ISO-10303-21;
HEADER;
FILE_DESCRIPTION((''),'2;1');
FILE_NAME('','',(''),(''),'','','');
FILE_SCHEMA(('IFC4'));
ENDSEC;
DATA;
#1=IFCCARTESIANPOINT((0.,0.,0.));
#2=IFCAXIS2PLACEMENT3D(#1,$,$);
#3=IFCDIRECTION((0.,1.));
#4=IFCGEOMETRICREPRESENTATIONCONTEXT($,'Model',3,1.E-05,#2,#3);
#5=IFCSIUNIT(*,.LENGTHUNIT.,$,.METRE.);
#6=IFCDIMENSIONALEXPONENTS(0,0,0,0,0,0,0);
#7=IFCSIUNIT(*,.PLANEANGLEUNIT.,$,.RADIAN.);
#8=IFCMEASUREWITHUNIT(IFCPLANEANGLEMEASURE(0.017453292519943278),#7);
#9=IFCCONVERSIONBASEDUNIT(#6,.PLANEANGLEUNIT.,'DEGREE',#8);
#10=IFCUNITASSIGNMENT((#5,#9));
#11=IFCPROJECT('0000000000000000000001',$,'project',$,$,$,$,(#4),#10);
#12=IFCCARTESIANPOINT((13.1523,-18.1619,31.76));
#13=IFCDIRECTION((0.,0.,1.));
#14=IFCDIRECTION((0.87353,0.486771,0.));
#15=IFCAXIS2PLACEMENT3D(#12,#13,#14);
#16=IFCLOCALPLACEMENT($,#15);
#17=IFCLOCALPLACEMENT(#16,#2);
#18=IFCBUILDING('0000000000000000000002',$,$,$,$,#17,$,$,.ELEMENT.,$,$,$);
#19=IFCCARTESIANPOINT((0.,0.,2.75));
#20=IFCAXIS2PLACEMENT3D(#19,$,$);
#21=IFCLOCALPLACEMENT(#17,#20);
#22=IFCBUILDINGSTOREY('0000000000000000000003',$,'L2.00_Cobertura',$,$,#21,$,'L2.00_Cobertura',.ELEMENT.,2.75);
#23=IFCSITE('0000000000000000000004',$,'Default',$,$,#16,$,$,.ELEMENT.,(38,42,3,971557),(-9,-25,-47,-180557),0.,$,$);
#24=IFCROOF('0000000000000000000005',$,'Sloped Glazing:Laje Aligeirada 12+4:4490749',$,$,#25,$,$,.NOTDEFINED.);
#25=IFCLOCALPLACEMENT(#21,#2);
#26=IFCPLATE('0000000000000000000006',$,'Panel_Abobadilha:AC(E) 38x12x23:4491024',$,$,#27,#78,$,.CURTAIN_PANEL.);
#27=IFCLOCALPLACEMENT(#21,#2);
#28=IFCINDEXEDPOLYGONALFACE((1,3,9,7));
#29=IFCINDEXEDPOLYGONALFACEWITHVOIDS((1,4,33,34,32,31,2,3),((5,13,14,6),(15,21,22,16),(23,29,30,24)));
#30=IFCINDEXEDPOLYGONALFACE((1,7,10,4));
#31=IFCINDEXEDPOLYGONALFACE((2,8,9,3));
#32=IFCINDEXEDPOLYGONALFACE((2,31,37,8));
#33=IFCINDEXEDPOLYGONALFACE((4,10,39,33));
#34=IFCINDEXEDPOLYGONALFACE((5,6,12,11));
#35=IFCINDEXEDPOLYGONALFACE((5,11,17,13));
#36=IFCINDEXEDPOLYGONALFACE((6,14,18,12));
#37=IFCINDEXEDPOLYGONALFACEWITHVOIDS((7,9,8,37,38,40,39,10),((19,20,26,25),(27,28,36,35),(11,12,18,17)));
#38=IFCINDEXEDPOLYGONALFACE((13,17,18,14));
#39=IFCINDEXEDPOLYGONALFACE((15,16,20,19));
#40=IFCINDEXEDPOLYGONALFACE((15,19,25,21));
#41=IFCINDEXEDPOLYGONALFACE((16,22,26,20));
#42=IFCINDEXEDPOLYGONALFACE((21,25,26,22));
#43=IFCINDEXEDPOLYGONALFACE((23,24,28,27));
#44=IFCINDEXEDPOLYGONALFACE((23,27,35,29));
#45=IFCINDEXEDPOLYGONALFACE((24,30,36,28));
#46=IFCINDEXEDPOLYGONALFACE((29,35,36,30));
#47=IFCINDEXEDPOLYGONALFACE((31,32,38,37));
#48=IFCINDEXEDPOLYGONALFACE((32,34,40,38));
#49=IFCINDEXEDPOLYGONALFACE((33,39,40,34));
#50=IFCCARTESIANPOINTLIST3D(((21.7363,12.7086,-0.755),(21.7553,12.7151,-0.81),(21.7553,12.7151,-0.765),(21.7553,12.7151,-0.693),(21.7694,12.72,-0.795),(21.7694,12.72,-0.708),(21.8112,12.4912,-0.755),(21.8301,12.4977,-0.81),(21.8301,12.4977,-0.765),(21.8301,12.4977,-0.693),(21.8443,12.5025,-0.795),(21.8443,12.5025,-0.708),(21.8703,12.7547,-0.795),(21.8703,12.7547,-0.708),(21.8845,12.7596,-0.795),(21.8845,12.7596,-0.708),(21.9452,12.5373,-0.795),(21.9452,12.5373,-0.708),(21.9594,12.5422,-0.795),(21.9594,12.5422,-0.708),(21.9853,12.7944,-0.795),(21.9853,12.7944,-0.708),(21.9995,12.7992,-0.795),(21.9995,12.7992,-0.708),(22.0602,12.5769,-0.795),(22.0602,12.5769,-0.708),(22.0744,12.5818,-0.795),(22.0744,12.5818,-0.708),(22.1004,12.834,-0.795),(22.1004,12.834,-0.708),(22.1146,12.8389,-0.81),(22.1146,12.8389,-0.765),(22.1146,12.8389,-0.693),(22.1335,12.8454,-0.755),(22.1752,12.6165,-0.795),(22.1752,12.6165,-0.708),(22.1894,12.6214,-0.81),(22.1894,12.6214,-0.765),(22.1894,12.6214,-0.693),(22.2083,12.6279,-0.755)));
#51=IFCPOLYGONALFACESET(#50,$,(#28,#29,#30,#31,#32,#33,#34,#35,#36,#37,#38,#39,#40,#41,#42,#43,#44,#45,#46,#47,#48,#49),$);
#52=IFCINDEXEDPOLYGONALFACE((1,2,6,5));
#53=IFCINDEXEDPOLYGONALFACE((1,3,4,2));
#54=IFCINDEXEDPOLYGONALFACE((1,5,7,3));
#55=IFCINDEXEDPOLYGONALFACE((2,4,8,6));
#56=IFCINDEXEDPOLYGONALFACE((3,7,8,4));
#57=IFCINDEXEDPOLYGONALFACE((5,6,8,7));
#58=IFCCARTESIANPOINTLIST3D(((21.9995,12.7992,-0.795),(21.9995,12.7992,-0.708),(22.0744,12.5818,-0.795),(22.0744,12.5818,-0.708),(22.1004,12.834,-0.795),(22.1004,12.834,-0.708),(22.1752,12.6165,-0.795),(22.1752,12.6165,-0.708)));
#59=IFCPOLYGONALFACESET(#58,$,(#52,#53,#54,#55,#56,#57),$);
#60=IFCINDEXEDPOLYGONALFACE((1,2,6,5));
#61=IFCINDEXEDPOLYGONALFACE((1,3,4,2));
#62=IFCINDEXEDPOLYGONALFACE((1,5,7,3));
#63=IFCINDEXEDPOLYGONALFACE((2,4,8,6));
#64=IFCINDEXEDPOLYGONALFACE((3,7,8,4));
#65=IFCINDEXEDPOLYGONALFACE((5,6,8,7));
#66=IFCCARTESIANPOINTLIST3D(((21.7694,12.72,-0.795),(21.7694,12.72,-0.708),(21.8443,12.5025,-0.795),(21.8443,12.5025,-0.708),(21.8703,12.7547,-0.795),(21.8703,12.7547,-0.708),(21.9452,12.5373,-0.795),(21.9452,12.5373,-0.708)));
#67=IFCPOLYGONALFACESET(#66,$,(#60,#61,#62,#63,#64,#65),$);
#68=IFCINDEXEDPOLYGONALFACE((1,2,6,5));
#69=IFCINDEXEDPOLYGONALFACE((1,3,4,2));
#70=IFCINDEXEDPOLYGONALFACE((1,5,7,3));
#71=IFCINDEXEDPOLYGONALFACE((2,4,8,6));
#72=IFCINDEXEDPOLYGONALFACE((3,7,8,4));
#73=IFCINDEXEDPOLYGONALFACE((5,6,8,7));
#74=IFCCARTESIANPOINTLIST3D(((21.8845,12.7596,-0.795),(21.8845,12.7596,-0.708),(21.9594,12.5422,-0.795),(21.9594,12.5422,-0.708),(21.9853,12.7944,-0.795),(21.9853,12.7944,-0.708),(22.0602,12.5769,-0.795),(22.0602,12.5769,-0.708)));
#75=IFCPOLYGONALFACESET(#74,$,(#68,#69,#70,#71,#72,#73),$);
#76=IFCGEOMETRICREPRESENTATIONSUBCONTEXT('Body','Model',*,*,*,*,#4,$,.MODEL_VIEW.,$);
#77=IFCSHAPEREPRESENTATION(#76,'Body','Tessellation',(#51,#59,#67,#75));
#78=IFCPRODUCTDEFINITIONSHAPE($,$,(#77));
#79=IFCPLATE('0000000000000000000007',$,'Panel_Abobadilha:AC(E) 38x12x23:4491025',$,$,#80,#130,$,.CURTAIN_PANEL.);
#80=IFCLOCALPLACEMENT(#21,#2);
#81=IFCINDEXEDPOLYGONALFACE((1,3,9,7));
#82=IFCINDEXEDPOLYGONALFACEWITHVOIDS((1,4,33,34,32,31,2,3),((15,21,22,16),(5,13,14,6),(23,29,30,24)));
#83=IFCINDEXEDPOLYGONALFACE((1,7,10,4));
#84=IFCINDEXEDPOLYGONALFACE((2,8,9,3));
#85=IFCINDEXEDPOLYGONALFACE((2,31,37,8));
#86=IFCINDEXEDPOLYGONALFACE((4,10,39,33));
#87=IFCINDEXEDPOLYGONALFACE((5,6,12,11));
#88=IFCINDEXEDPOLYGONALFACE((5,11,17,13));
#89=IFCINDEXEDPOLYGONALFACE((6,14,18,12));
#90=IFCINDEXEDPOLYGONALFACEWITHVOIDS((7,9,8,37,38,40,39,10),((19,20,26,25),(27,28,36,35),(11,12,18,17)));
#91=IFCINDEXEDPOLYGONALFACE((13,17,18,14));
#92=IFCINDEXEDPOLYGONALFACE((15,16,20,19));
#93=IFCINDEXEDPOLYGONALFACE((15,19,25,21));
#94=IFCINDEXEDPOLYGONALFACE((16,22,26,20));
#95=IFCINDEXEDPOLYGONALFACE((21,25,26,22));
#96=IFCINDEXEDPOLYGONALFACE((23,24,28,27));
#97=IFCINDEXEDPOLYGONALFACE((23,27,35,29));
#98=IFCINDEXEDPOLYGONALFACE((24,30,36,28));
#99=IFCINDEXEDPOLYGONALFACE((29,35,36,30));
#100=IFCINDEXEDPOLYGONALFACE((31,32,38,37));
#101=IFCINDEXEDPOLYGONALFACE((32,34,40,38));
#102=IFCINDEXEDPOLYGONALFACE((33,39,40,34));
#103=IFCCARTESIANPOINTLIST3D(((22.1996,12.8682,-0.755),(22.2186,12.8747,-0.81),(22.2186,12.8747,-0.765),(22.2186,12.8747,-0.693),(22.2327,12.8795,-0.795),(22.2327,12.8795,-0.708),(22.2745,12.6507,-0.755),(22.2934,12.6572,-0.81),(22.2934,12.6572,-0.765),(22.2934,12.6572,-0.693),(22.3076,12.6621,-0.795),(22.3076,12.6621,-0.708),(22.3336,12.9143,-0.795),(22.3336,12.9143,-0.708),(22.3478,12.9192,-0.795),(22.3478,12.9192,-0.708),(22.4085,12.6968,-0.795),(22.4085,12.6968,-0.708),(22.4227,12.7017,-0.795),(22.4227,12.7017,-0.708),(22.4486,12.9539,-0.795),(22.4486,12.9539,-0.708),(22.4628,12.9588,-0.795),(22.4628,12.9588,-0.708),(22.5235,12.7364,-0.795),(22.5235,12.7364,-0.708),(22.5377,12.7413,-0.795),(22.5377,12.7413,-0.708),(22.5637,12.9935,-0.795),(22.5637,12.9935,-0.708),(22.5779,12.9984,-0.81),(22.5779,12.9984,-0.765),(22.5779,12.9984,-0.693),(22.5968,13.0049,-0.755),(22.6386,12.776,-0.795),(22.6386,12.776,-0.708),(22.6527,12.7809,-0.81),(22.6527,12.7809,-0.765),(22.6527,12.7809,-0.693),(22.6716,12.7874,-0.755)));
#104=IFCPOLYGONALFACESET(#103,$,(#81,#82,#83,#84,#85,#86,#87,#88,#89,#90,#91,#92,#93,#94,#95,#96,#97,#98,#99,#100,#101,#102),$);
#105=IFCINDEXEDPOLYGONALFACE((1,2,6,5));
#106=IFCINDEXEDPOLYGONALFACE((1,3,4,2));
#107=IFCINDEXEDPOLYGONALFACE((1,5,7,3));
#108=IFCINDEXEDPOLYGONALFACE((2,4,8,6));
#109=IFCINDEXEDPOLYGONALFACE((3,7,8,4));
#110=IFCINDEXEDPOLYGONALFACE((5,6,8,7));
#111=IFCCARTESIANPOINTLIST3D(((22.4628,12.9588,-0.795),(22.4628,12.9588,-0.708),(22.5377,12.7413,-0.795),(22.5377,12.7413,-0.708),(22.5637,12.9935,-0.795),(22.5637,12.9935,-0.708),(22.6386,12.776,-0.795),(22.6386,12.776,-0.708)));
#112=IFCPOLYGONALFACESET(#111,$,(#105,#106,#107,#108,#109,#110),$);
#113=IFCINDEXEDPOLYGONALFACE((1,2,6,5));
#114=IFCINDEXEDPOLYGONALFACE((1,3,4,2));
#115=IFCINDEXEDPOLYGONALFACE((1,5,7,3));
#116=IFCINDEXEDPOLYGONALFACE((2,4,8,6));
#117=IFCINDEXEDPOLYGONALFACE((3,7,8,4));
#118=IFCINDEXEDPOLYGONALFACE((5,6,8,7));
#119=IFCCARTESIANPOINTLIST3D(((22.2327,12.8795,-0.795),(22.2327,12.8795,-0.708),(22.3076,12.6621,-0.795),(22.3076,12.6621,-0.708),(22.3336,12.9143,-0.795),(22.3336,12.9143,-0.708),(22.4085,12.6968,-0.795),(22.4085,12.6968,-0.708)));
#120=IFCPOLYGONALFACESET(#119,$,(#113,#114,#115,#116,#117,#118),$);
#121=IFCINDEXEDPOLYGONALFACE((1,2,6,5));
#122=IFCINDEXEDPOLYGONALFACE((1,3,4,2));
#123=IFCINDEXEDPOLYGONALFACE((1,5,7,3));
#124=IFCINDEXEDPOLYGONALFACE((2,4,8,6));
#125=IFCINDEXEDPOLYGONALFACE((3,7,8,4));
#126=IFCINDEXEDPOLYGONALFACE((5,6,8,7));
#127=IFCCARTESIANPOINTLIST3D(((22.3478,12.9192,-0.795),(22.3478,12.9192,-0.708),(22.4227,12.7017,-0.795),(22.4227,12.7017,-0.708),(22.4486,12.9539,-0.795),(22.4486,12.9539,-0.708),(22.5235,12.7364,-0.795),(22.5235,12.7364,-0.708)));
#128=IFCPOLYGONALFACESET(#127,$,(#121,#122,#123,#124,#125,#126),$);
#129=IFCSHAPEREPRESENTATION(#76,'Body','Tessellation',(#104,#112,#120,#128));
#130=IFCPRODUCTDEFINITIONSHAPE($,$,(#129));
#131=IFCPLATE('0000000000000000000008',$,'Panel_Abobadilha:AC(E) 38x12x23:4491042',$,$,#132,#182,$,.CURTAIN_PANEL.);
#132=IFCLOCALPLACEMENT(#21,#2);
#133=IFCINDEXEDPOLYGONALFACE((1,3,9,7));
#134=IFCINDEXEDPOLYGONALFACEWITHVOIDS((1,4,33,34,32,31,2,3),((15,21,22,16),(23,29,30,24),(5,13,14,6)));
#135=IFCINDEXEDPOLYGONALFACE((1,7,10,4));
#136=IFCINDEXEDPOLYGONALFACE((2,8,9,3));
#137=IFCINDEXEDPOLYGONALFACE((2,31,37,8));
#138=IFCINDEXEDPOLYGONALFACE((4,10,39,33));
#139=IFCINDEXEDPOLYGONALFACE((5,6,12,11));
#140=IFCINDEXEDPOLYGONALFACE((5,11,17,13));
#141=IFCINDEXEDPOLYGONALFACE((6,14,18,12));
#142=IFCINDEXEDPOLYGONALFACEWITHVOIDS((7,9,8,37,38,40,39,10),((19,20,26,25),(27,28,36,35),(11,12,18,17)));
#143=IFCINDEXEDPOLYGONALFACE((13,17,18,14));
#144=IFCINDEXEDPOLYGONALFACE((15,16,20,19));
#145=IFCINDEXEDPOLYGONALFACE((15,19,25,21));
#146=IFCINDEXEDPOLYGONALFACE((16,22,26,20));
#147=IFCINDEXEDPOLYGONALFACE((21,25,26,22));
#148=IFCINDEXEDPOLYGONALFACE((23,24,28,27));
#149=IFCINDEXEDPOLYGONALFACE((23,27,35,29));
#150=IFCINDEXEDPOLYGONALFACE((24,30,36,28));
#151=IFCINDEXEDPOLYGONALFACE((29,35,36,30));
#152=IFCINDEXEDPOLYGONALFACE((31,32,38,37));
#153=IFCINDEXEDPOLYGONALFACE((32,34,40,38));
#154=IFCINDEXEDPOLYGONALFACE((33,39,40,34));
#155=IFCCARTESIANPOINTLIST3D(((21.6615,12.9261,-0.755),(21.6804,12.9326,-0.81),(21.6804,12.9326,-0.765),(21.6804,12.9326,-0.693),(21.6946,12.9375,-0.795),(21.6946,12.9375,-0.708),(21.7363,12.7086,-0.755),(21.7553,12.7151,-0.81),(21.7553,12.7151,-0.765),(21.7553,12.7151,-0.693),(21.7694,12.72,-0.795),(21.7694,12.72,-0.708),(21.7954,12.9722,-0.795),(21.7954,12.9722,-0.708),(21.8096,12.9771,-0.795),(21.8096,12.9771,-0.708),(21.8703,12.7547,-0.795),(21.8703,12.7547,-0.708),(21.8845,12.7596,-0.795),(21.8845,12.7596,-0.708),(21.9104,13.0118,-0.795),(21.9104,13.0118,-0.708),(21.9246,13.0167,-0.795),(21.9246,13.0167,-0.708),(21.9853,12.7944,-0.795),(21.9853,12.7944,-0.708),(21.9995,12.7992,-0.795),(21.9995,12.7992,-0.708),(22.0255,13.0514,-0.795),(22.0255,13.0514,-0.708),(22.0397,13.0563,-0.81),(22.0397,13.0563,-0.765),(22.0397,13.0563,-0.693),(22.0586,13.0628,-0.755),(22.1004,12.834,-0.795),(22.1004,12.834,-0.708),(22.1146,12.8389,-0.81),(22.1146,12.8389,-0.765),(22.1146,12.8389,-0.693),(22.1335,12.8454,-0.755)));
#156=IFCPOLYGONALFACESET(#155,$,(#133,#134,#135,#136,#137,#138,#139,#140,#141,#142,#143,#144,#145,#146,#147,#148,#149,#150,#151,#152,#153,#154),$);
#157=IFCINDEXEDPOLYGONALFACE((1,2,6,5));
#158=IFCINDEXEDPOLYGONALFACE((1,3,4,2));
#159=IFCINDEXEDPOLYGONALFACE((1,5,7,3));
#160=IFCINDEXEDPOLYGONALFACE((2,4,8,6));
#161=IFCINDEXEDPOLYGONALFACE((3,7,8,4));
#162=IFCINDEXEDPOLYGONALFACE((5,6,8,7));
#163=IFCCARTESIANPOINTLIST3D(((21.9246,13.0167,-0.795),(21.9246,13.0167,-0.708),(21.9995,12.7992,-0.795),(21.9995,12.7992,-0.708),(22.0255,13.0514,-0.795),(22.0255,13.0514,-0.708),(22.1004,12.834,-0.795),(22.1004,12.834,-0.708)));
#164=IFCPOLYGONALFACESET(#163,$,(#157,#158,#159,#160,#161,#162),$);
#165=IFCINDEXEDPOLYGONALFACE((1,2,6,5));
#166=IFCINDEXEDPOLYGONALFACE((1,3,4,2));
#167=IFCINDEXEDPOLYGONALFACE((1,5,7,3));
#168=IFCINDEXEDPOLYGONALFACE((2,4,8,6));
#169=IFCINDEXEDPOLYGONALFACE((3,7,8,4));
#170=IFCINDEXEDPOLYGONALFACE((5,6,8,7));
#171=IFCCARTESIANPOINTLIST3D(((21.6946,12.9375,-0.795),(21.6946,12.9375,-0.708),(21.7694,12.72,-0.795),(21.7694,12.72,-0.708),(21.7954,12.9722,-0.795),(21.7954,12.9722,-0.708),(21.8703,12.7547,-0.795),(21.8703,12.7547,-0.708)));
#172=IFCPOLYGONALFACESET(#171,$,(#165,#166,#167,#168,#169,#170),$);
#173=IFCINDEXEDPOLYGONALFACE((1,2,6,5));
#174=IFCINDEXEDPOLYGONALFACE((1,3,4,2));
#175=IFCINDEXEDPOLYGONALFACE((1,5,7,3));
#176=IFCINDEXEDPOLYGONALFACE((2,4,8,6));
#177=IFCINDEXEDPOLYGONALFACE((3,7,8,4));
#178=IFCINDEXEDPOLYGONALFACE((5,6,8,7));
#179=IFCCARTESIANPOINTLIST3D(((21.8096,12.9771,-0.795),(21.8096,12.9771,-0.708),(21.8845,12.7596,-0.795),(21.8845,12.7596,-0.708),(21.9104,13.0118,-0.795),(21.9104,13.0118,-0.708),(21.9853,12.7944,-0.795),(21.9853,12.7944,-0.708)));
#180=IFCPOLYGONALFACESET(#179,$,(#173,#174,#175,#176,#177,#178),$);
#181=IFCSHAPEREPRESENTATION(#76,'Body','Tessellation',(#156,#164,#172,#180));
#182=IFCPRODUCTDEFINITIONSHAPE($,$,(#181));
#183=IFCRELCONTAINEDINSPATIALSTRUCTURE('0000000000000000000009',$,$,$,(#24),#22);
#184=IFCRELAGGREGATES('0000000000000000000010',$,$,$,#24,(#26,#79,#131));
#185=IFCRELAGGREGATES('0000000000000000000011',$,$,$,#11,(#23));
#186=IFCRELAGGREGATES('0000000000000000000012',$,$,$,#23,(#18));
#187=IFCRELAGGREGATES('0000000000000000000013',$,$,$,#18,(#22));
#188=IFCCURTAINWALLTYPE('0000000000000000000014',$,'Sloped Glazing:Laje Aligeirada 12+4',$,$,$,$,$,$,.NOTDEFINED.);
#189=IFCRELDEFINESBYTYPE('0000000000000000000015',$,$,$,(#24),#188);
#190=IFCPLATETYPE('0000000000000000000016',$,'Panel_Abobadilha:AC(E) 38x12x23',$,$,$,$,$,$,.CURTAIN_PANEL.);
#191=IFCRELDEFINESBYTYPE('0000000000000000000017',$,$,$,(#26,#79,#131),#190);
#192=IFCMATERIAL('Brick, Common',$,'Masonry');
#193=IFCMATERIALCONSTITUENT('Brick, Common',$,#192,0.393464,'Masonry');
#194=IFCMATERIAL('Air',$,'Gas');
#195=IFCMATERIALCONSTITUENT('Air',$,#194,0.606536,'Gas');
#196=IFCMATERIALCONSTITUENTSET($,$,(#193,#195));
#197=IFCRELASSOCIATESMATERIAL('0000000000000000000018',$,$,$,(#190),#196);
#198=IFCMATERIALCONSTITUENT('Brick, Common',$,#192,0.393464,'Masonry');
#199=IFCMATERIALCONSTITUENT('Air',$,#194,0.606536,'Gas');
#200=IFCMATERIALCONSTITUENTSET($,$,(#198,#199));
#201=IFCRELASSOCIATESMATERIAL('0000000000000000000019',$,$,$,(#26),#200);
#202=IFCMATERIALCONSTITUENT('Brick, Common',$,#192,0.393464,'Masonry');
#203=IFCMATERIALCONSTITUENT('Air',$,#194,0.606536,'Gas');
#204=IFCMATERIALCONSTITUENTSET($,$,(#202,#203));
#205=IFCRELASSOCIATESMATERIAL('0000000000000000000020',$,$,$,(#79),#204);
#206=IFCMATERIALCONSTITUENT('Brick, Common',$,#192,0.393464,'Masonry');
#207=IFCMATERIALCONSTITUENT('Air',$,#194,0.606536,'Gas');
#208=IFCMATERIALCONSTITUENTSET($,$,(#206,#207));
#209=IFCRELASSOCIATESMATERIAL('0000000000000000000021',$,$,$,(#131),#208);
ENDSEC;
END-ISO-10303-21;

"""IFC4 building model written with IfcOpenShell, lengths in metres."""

from ifc_helpers import new_model, entity, si_unit, converted_unit, direction, frame, origin, place, context, subcontext, project, spatial, indexed_curve, outline, extrude, source, transform, mapped, material, constituent, constituent_set, type_object, type_shapes, element, aggregate, save


model = new_model("IFC4")

# Units and contexts
model_context = context("Model", 3, precision=1e-05, world=origin(), true_north=direction((0.0, 1.0)))
body_context = subcontext(model_context, "Body", "Model", "MODEL_VIEW")
ifc_project = project(units=[si_unit("LENGTHUNIT", "METRE"), converted_unit("PLANEANGLEUNIT", "DEGREE", entity("IfcPlaneAngleMeasure", 0.017453292519943278), si_unit("PLANEANGLEUNIT", "RADIAN"), dimensions=[0, 0, 0, 0, 0, 0, 0])], contexts=[model_context])

# Site, building, storey
site_placement = place(None, frame((13.1523, -18.1619, 31.76), z_axis=(0.0, 0.0, 1.0), x_axis=(0.87353, 0.486771, 0.0)))
site = spatial("IfcSite", under=ifc_project, at=site_placement, Name="Default", CompositionType="ELEMENT", RefLatitude=(38, 42, 3, 971557), RefLongitude=(-9, -25, -47, -180557), RefElevation=0.0)
building_placement = place(site_placement, origin())
building = spatial("IfcBuilding", under=site, at=building_placement, CompositionType="ELEMENT")
storey_placement = place(building_placement, frame((0.0, 0.0, 2.75)))
storey = spatial("IfcBuildingStorey", under=building, at=storey_placement, Name="L2.00_Cobertura", LongName="L2.00_Cobertura", CompositionType="ELEMENT", Elevation=2.75)

# Roof, plates
curtain_wall_type = type_object("IfcCurtainWallType", Name="Sloped Glazing:Laje Aligeirada 12+4", PredefinedType="NOTDEFINED")
roof_placement = place(storey_placement, frame((0.0, 0.0, -2.75)))
roof = element("IfcRoof", 1, at=roof_placement, inside=storey, type_object=curtain_wall_type, Name="Sloped Glazing:Laje Aligeirada 12+4:4490749", PredefinedType="NOTDEFINED")
ifc_material_1 = material(Name="Brick, Common", Category="Masonry")
ifc_material_2 = material(Name="Air", Category="Gas")
ifc_constituent_1 = constituent(ifc_material_1, Name="Brick, Common", Category="Masonry", fraction=0.393464)
ifc_constituent_2 = constituent(ifc_material_2, Name="Air", Category="Gas", fraction=0.606536)
ifc_constituent_set_1 = constituent_set(constituents=[ifc_constituent_1, ifc_constituent_2])
plate_type = type_object("IfcPlateType", Name="Panel_Abobadilha:AC(E) 38x12x23", PredefinedType="CURTAIN_PANEL", material=ifc_constituent_set_1)
shared_shape_1 = source(origin(), body_context, "Body", "SweptSolid", [
    extrude(outline(indexed_curve([(-0.19, -0.0543), (0.19, -0.0543), (0.19, -0.0093), (0.21, 0.0007), (0.19, 0.0628), (-0.19, 0.0628), (-0.21, 0.0007), (-0.19, -0.0093), (-0.19, -0.0543)], self_intersect=False), holes=[indexed_curve([(-0.0683, 0.0477), (-0.0683, -0.0393), (-0.175, -0.0393), (-0.175, 0.0477), (-0.0683, 0.0477)], self_intersect=False), indexed_curve([(0.0533, 0.0477), (0.0533, -0.0393), (-0.0533, -0.0393), (-0.0533, 0.0477), (0.0533, 0.0477)], self_intersect=False), indexed_curve([(0.175, 0.0477), (0.175, -0.0393), (0.0683, -0.0393), (0.0683, 0.0477), (0.175, 0.0477)], self_intersect=False)]), frame((0.0, 0.0543, 0.0)), (0.0, 0.0, 1.0), 0.23),
    extrude(outline(indexed_curve([(-0.0533, -0.0435), (0.0533, -0.0435), (0.0533, 0.0435), (-0.0533, 0.0435), (-0.0533, -0.0435)], self_intersect=False)), frame((0.1217, 0.0585, 0.0), z_axis=(0.0, 0.0, 1.0), x_axis=(-1.0, 0.0, 0.0)), (0.0, 0.0, 1.0), 0.23),
    extrude(outline(indexed_curve([(-0.0533, -0.0435), (0.0533, -0.0435), (0.0533, 0.0435), (-0.0533, 0.0435), (-0.0533, -0.0435)], self_intersect=False)), frame((-0.1217, 0.0585, 0.0), z_axis=(0.0, 0.0, 1.0), x_axis=(-1.0, 0.0, 0.0)), (0.0, 0.0, 1.0), 0.23),
    extrude(outline(indexed_curve([(-0.0533, -0.0435), (0.0533, -0.0435), (0.0533, 0.0435), (-0.0533, 0.0435), (-0.0533, -0.0435)], self_intersect=False)), frame((0.0, 0.0585, 0.0), z_axis=(0.0, 0.0, 1.0), x_axis=(-1.0, 0.0, 0.0)), (0.0, 0.0, 1.0), 0.23),
])
type_shapes(plate_type, [shared_shape_1])
ifc_constituent_3 = constituent(ifc_material_1, Name="Brick, Common", Category="Masonry", fraction=0.393464)
ifc_constituent_4 = constituent(ifc_material_2, Name="Air", Category="Gas", fraction=0.606536)
ifc_constituent_set_2 = constituent_set(constituents=[ifc_constituent_3, ifc_constituent_4])
plate_1_placement = place(roof_placement, frame((21.9349, 12.777, 1.94), z_axis=(0.325568, -0.945519, 0.0), x_axis=(0.945519, 0.325568, 0.0)))
plate_1 = element("IfcPlate", 2, at=plate_1_placement, type_object=plate_type, material=ifc_constituent_set_2, Name="Panel_Abobadilha:AC(E) 38x12x23:4491024", PredefinedType="CURTAIN_PANEL", context=body_context, shape_type="MappedRepresentation", body=[
    mapped(shared_shape_1, transform((0.0, 0.0, 0.0), scale=1.0)),
])
ifc_constituent_5 = constituent(ifc_material_1, Name="Brick, Common", Category="Masonry", fraction=0.393464)
ifc_constituent_6 = constituent(ifc_material_2, Name="Air", Category="Gas", fraction=0.606536)
ifc_constituent_set_3 = constituent_set(constituents=[ifc_constituent_5, ifc_constituent_6])
plate_2_placement = place(roof_placement, frame((22.3982, 12.9365, 1.94), z_axis=(0.325568, -0.945519, 0.0), x_axis=(0.945519, 0.325568, 0.0)))
plate_2 = element("IfcPlate", 3, at=plate_2_placement, type_object=plate_type, material=ifc_constituent_set_3, Name="Panel_Abobadilha:AC(E) 38x12x23:4491025", PredefinedType="CURTAIN_PANEL", context=body_context, shape_type="MappedRepresentation", body=[
    mapped(shared_shape_1, transform((0.0, 0.0, 0.0), scale=1.0)),
])
ifc_constituent_7 = constituent(ifc_material_1, Name="Brick, Common", Category="Masonry", fraction=0.393464)
ifc_constituent_8 = constituent(ifc_material_2, Name="Air", Category="Gas", fraction=0.606536)
ifc_constituent_set_4 = constituent_set(constituents=[ifc_constituent_7, ifc_constituent_8])
plate_3_placement = place(roof_placement, frame((21.86, 12.9945, 1.94), z_axis=(0.325568, -0.945519, 0.0), x_axis=(0.945519, 0.325568, 0.0)))
plate_3 = element("IfcPlate", 4, at=plate_3_placement, type_object=plate_type, material=ifc_constituent_set_4, Name="Panel_Abobadilha:AC(E) 38x12x23:4491042", PredefinedType="CURTAIN_PANEL", context=body_context, shape_type="MappedRepresentation", body=[
    mapped(shared_shape_1, transform((0.0, 0.0, 0.0), scale=1.0)),
])
aggregate(roof, [plate_1, plate_2, plate_3])

save(model, "model.ifc")
